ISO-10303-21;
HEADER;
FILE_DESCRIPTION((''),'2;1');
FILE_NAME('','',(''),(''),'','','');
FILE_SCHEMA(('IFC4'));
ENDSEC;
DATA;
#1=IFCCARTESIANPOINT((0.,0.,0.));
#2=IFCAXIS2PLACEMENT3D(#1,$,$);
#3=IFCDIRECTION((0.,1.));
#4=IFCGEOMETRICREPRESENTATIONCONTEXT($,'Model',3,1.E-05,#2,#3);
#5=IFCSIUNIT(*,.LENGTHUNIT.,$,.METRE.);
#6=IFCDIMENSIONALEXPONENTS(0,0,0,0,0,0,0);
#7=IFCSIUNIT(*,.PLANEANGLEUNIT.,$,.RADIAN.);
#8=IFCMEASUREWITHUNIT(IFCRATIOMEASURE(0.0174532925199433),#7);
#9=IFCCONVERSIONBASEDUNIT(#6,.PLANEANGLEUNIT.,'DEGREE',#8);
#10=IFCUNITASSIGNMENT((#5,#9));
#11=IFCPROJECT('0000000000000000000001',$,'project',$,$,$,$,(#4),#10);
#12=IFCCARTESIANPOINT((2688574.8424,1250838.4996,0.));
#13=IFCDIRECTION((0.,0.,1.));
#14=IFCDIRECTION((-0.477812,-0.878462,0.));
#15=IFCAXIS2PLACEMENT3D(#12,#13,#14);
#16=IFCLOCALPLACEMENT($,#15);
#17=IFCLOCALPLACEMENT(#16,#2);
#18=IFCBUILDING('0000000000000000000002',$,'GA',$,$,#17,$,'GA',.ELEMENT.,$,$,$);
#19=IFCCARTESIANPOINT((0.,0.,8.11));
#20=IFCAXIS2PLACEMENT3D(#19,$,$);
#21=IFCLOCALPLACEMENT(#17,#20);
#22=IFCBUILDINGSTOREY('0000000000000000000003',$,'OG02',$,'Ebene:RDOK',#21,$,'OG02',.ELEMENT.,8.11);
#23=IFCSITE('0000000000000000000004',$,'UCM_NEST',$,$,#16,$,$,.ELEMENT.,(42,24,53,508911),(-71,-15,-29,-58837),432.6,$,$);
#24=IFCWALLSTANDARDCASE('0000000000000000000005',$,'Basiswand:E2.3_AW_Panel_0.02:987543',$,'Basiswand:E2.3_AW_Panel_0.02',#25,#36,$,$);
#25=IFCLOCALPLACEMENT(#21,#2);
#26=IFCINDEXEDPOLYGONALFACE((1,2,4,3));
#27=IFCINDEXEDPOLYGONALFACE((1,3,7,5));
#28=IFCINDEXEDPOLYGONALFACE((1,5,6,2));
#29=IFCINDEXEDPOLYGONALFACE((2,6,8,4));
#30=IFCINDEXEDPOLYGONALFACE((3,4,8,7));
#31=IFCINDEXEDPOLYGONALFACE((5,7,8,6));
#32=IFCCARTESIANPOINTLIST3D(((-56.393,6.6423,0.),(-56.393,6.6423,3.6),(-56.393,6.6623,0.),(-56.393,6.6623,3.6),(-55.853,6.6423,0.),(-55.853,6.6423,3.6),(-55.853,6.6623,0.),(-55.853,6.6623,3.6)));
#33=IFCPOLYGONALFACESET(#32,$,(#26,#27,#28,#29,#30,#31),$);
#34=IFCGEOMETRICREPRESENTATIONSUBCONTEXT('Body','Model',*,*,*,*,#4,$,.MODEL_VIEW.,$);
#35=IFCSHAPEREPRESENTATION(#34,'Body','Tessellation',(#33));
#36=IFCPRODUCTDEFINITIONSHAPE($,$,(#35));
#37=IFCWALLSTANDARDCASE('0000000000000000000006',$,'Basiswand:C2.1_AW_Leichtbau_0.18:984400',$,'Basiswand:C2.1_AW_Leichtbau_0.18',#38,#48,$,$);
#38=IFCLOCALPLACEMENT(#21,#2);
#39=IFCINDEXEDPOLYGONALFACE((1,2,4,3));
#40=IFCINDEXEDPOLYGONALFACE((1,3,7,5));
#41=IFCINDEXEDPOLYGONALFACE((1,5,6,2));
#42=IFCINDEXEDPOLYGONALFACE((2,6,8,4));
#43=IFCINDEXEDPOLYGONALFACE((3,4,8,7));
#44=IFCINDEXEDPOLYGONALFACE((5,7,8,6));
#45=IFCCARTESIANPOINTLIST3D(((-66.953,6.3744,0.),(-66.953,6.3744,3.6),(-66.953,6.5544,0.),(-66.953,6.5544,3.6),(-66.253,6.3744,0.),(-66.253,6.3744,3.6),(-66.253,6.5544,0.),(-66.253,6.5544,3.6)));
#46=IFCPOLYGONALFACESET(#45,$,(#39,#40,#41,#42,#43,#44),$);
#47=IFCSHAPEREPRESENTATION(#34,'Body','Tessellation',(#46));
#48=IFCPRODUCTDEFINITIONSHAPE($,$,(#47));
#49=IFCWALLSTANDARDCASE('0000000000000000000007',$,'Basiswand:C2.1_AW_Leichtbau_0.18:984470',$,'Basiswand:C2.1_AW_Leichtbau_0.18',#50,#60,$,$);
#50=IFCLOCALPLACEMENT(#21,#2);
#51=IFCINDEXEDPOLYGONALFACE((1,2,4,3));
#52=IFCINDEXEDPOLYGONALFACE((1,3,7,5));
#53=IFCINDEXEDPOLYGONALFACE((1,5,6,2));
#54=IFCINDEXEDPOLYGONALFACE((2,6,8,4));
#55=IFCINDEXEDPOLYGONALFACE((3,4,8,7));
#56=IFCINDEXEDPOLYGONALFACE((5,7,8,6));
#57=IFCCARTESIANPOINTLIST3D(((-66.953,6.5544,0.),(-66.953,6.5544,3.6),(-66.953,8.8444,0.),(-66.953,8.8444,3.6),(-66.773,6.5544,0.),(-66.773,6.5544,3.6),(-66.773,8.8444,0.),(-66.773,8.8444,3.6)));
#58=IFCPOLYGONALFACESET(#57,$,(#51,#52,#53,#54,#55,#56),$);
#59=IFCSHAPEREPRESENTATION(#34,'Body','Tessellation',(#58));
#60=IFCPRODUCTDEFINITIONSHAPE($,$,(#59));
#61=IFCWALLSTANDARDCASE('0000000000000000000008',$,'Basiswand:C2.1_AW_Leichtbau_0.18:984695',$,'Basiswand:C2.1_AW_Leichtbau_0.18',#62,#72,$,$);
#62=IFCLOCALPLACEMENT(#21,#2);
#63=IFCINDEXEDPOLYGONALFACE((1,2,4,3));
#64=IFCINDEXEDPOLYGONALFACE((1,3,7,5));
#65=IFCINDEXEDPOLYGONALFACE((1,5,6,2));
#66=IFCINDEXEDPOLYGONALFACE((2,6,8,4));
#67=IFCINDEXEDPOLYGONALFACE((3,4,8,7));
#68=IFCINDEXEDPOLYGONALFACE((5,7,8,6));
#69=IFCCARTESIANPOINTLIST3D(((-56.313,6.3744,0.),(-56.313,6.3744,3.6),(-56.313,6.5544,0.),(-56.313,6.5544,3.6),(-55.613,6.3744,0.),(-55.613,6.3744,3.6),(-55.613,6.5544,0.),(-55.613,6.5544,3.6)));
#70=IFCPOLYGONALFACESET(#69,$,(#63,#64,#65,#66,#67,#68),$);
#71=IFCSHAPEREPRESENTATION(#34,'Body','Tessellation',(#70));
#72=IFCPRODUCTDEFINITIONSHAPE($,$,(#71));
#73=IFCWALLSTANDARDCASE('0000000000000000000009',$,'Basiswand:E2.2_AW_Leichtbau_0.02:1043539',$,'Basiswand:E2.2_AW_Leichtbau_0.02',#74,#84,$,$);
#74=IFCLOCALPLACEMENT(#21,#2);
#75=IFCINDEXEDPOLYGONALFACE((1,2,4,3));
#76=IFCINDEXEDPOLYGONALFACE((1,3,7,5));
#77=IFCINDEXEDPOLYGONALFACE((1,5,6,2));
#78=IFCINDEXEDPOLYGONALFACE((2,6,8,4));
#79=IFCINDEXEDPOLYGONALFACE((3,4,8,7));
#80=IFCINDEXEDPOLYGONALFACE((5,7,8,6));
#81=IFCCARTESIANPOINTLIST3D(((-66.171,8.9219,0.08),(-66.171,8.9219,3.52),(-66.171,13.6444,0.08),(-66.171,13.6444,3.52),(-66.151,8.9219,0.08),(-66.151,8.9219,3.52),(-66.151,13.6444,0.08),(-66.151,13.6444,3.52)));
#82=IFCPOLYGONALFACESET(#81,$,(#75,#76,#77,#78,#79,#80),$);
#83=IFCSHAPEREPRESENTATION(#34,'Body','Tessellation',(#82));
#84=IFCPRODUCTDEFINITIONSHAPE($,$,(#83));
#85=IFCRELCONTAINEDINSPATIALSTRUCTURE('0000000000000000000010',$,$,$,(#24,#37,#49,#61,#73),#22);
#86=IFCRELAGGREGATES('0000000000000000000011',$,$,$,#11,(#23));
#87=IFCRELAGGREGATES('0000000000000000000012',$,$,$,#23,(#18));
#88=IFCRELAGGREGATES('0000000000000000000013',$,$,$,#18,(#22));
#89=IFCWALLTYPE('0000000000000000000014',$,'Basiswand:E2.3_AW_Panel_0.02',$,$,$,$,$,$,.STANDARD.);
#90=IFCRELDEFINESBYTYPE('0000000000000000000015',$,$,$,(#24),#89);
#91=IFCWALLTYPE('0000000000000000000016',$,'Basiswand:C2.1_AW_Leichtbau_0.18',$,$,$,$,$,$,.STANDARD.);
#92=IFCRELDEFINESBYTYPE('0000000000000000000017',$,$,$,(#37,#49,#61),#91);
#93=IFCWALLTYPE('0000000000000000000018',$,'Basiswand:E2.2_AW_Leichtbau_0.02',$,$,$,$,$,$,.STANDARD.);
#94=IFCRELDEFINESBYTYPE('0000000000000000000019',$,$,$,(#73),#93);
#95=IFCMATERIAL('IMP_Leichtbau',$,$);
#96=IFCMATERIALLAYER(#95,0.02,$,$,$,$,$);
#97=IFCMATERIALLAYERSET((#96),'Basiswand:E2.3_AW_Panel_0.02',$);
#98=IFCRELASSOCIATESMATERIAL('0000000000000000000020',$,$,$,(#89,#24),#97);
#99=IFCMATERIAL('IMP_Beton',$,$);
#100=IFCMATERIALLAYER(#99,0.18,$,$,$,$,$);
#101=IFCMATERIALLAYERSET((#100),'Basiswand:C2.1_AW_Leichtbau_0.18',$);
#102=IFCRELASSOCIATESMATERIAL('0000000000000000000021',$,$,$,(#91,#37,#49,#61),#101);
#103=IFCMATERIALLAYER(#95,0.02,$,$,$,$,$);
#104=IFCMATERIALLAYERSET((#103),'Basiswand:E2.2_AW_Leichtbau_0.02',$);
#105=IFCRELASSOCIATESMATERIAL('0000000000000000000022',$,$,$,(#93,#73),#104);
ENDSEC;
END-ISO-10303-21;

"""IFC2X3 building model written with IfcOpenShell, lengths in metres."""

from ifc_helpers import new_model, entity, si_unit, converted_unit, direction, frame, frame_2d, origin, place, context, subcontext, project, spatial, polyline, rectangle, extrude, clip, bounded_halfspace, material, layer, layer_set, layer_usage, type_object, element, save


model = new_model("IFC2X3")

# Units and contexts
model_context = context("Model", 3, precision=1e-05, world=origin(), true_north=direction((0.0, 1.0)))
body_context = subcontext(model_context, "Body", "Model", "MODEL_VIEW")
ifc_project = project(units=[si_unit("LENGTHUNIT", "METRE"), converted_unit("PLANEANGLEUNIT", "DEGREE", entity("IfcRatioMeasure", 0.0174532925199433), si_unit("PLANEANGLEUNIT", "RADIAN"), dimensions=[0, 0, 0, 0, 0, 0, 0])], contexts=[model_context])

# Site, building, storey
site_placement = place(None, frame((2688574.8424, 1250838.4996, 0.0), z_axis=(0.0, 0.0, 1.0), x_axis=(-0.477812, -0.878462, 0.0)))
site = spatial("IfcSite", under=ifc_project, at=site_placement, Name="UCM_NEST", CompositionType="ELEMENT", RefLatitude=(42, 24, 53, 508911), RefLongitude=(-71, -15, -29, -58837), RefElevation=432.6)
building_placement = place(site_placement, origin())
building = spatial("IfcBuilding", under=site, at=building_placement, Name="GA", LongName="GA", CompositionType="ELEMENT")
storey_placement = place(building_placement, frame((0.0, 0.0, 8.11)))
storey = spatial("IfcBuildingStorey", under=building, at=storey_placement, Name="OG02", ObjectType="Ebene:RDOK", LongName="OG02", CompositionType="ELEMENT", Elevation=8.11)

# Walls
ifc_material_1 = material(Name="IMP_Leichtbau")
ifc_layer_1 = layer(ifc_material_1, 0.02)
ifc_layer_set_1 = layer_set([ifc_layer_1], Name="Basiswand:E2.3_AW_Panel_0.02")
wall_type_1 = type_object("IfcWallType", Name="Basiswand:E2.3_AW_Panel_0.02", PredefinedType="STANDARD", material=ifc_layer_set_1)
ifc_layer_usage_1 = layer_usage(ifc_layer_set_1, "AXIS2", "NEGATIVE", 0.01)
wall_1_placement = place(storey_placement, frame((-56.393, 6.6523, 0.0)))
element("IfcWallStandardCase", 1, at=wall_1_placement, inside=storey, type_object=wall_type_1, material=ifc_layer_usage_1, Name="Basiswand:E2.3_AW_Panel_0.02:987543", ObjectType="Basiswand:E2.3_AW_Panel_0.02", context=body_context, shape_type="SweptSolid", body=[
    extrude(rectangle(XDim=0.54, YDim=0.02, at=frame_2d((0.27, 0.0), x_axis=(-1.0, 0.0))), origin(), (0.0, 0.0, 1.0), 3.6),
])
ifc_material_2 = material(Name="IMP_Beton")
ifc_layer_2 = layer(ifc_material_2, 0.18)
ifc_layer_set_2 = layer_set([ifc_layer_2], Name="Basiswand:C2.1_AW_Leichtbau_0.18")
ifc_layer_usage_2 = layer_usage(ifc_layer_set_2, "AXIS2", "NEGATIVE", 0.09)
wall_type_2 = type_object("IfcWallType", Name="Basiswand:C2.1_AW_Leichtbau_0.18", PredefinedType="STANDARD", material=ifc_layer_set_2)
wall_2_placement = place(storey_placement, frame((-66.253, 6.4644, 0.0), z_axis=(0.0, 0.0, 1.0), x_axis=(-1.0, 0.0, 0.0)))
element("IfcWallStandardCase", 2, at=wall_2_placement, inside=storey, type_object=wall_type_2, material=ifc_layer_usage_2, Name="Basiswand:C2.1_AW_Leichtbau_0.18:984400", ObjectType="Basiswand:C2.1_AW_Leichtbau_0.18", context=body_context, shape_type="SweptSolid", body=[
    extrude(rectangle(XDim=0.7, YDim=0.18, at=frame_2d((0.35, 0.0), x_axis=(-1.0, 0.0))), origin(), (0.0, 0.0, 1.0), 3.6),
])
ifc_layer_usage_3 = layer_usage(ifc_layer_set_2, "AXIS2", "NEGATIVE", 0.09)
wall_3_placement = place(storey_placement, frame((-66.863, 6.5544, 0.0), z_axis=(0.0, 0.0, 1.0), x_axis=(0.0, 1.0, 0.0)))
element("IfcWallStandardCase", 3, at=wall_3_placement, inside=storey, type_object=wall_type_2, material=ifc_layer_usage_3, Name="Basiswand:C2.1_AW_Leichtbau_0.18:984470", ObjectType="Basiswand:C2.1_AW_Leichtbau_0.18", context=body_context, shape_type="SweptSolid", body=[
    extrude(rectangle(XDim=2.29, YDim=0.18, at=frame_2d((1.145, 0.0), x_axis=(-1.0, 0.0))), origin(), (0.0, 0.0, 1.0), 3.6),
])
ifc_layer_usage_4 = layer_usage(ifc_layer_set_2, "AXIS2", "NEGATIVE", 0.09)
wall_4_placement = place(storey_placement, frame((-56.313, 6.4644, 0.0)))
element("IfcWallStandardCase", 4, at=wall_4_placement, inside=storey, type_object=wall_type_2, material=ifc_layer_usage_4, Name="Basiswand:C2.1_AW_Leichtbau_0.18:984695", ObjectType="Basiswand:C2.1_AW_Leichtbau_0.18", context=body_context, shape_type="SweptSolid", body=[
    extrude(rectangle(XDim=0.7, YDim=0.18, at=frame_2d((0.35, 0.0), x_axis=(-1.0, 0.0))), origin(), (0.0, 0.0, 1.0), 3.6),
])
ifc_layer_3 = layer(ifc_material_1, 0.02)
ifc_layer_set_3 = layer_set([ifc_layer_3], Name="Basiswand:E2.2_AW_Leichtbau_0.02")
ifc_layer_usage_5 = layer_usage(ifc_layer_set_3, "AXIS2", "NEGATIVE", 0.01)
wall_type_3 = type_object("IfcWallType", Name="Basiswand:E2.2_AW_Leichtbau_0.02", PredefinedType="STANDARD", material=ifc_layer_set_3)
wall_5_placement = place(storey_placement, frame((-66.161, 8.9219, 0.08), z_axis=(0.0, 0.0, 1.0), x_axis=(0.0, 1.0, 0.0)))
element("IfcWallStandardCase", 5, at=wall_5_placement, inside=storey, type_object=wall_type_3, material=ifc_layer_usage_5, Name="Basiswand:E2.2_AW_Leichtbau_0.02:1043539", ObjectType="Basiswand:E2.2_AW_Leichtbau_0.02", context=body_context, shape_type="Clipping", body=[
    clip(clip(extrude(rectangle(XDim=4.7226, YDim=0.02, at=frame_2d((2.3613, 0.0), x_axis=(-1.0, 0.0))), origin(), (0.0, 0.0, 1.0), 3.44), bounded_halfspace(frame((4.7226, -0.01, 0.0), z_axis=(0.0, 0.0, 1.0), x_axis=(0.0, 1.0, 0.0)), True, frame((4.7226, -0.01, 0.0), z_axis=(0.0, 0.0, 1.0), x_axis=(0.0, 1.0, 0.0)), polyline([(0.0, 0.0), (0.02, 0.0), (0.02, 4.7226), (0.0, 4.7226), (0.0, 0.0)]))), bounded_halfspace(frame((0.0, -0.01, 3.44), z_axis=(0.0, 0.0, -1.0), x_axis=(0.0, 1.0, 0.0)), True, frame((0.0, -0.01, 3.44), z_axis=(0.0, 0.0, -1.0), x_axis=(0.0, 1.0, 0.0)), polyline([(0.0, 0.0), (0.02, 0.0), (0.02, 4.7226), (0.0, 4.7226), (0.0, 0.0)]))),
])

save(model, "model.ifc")
